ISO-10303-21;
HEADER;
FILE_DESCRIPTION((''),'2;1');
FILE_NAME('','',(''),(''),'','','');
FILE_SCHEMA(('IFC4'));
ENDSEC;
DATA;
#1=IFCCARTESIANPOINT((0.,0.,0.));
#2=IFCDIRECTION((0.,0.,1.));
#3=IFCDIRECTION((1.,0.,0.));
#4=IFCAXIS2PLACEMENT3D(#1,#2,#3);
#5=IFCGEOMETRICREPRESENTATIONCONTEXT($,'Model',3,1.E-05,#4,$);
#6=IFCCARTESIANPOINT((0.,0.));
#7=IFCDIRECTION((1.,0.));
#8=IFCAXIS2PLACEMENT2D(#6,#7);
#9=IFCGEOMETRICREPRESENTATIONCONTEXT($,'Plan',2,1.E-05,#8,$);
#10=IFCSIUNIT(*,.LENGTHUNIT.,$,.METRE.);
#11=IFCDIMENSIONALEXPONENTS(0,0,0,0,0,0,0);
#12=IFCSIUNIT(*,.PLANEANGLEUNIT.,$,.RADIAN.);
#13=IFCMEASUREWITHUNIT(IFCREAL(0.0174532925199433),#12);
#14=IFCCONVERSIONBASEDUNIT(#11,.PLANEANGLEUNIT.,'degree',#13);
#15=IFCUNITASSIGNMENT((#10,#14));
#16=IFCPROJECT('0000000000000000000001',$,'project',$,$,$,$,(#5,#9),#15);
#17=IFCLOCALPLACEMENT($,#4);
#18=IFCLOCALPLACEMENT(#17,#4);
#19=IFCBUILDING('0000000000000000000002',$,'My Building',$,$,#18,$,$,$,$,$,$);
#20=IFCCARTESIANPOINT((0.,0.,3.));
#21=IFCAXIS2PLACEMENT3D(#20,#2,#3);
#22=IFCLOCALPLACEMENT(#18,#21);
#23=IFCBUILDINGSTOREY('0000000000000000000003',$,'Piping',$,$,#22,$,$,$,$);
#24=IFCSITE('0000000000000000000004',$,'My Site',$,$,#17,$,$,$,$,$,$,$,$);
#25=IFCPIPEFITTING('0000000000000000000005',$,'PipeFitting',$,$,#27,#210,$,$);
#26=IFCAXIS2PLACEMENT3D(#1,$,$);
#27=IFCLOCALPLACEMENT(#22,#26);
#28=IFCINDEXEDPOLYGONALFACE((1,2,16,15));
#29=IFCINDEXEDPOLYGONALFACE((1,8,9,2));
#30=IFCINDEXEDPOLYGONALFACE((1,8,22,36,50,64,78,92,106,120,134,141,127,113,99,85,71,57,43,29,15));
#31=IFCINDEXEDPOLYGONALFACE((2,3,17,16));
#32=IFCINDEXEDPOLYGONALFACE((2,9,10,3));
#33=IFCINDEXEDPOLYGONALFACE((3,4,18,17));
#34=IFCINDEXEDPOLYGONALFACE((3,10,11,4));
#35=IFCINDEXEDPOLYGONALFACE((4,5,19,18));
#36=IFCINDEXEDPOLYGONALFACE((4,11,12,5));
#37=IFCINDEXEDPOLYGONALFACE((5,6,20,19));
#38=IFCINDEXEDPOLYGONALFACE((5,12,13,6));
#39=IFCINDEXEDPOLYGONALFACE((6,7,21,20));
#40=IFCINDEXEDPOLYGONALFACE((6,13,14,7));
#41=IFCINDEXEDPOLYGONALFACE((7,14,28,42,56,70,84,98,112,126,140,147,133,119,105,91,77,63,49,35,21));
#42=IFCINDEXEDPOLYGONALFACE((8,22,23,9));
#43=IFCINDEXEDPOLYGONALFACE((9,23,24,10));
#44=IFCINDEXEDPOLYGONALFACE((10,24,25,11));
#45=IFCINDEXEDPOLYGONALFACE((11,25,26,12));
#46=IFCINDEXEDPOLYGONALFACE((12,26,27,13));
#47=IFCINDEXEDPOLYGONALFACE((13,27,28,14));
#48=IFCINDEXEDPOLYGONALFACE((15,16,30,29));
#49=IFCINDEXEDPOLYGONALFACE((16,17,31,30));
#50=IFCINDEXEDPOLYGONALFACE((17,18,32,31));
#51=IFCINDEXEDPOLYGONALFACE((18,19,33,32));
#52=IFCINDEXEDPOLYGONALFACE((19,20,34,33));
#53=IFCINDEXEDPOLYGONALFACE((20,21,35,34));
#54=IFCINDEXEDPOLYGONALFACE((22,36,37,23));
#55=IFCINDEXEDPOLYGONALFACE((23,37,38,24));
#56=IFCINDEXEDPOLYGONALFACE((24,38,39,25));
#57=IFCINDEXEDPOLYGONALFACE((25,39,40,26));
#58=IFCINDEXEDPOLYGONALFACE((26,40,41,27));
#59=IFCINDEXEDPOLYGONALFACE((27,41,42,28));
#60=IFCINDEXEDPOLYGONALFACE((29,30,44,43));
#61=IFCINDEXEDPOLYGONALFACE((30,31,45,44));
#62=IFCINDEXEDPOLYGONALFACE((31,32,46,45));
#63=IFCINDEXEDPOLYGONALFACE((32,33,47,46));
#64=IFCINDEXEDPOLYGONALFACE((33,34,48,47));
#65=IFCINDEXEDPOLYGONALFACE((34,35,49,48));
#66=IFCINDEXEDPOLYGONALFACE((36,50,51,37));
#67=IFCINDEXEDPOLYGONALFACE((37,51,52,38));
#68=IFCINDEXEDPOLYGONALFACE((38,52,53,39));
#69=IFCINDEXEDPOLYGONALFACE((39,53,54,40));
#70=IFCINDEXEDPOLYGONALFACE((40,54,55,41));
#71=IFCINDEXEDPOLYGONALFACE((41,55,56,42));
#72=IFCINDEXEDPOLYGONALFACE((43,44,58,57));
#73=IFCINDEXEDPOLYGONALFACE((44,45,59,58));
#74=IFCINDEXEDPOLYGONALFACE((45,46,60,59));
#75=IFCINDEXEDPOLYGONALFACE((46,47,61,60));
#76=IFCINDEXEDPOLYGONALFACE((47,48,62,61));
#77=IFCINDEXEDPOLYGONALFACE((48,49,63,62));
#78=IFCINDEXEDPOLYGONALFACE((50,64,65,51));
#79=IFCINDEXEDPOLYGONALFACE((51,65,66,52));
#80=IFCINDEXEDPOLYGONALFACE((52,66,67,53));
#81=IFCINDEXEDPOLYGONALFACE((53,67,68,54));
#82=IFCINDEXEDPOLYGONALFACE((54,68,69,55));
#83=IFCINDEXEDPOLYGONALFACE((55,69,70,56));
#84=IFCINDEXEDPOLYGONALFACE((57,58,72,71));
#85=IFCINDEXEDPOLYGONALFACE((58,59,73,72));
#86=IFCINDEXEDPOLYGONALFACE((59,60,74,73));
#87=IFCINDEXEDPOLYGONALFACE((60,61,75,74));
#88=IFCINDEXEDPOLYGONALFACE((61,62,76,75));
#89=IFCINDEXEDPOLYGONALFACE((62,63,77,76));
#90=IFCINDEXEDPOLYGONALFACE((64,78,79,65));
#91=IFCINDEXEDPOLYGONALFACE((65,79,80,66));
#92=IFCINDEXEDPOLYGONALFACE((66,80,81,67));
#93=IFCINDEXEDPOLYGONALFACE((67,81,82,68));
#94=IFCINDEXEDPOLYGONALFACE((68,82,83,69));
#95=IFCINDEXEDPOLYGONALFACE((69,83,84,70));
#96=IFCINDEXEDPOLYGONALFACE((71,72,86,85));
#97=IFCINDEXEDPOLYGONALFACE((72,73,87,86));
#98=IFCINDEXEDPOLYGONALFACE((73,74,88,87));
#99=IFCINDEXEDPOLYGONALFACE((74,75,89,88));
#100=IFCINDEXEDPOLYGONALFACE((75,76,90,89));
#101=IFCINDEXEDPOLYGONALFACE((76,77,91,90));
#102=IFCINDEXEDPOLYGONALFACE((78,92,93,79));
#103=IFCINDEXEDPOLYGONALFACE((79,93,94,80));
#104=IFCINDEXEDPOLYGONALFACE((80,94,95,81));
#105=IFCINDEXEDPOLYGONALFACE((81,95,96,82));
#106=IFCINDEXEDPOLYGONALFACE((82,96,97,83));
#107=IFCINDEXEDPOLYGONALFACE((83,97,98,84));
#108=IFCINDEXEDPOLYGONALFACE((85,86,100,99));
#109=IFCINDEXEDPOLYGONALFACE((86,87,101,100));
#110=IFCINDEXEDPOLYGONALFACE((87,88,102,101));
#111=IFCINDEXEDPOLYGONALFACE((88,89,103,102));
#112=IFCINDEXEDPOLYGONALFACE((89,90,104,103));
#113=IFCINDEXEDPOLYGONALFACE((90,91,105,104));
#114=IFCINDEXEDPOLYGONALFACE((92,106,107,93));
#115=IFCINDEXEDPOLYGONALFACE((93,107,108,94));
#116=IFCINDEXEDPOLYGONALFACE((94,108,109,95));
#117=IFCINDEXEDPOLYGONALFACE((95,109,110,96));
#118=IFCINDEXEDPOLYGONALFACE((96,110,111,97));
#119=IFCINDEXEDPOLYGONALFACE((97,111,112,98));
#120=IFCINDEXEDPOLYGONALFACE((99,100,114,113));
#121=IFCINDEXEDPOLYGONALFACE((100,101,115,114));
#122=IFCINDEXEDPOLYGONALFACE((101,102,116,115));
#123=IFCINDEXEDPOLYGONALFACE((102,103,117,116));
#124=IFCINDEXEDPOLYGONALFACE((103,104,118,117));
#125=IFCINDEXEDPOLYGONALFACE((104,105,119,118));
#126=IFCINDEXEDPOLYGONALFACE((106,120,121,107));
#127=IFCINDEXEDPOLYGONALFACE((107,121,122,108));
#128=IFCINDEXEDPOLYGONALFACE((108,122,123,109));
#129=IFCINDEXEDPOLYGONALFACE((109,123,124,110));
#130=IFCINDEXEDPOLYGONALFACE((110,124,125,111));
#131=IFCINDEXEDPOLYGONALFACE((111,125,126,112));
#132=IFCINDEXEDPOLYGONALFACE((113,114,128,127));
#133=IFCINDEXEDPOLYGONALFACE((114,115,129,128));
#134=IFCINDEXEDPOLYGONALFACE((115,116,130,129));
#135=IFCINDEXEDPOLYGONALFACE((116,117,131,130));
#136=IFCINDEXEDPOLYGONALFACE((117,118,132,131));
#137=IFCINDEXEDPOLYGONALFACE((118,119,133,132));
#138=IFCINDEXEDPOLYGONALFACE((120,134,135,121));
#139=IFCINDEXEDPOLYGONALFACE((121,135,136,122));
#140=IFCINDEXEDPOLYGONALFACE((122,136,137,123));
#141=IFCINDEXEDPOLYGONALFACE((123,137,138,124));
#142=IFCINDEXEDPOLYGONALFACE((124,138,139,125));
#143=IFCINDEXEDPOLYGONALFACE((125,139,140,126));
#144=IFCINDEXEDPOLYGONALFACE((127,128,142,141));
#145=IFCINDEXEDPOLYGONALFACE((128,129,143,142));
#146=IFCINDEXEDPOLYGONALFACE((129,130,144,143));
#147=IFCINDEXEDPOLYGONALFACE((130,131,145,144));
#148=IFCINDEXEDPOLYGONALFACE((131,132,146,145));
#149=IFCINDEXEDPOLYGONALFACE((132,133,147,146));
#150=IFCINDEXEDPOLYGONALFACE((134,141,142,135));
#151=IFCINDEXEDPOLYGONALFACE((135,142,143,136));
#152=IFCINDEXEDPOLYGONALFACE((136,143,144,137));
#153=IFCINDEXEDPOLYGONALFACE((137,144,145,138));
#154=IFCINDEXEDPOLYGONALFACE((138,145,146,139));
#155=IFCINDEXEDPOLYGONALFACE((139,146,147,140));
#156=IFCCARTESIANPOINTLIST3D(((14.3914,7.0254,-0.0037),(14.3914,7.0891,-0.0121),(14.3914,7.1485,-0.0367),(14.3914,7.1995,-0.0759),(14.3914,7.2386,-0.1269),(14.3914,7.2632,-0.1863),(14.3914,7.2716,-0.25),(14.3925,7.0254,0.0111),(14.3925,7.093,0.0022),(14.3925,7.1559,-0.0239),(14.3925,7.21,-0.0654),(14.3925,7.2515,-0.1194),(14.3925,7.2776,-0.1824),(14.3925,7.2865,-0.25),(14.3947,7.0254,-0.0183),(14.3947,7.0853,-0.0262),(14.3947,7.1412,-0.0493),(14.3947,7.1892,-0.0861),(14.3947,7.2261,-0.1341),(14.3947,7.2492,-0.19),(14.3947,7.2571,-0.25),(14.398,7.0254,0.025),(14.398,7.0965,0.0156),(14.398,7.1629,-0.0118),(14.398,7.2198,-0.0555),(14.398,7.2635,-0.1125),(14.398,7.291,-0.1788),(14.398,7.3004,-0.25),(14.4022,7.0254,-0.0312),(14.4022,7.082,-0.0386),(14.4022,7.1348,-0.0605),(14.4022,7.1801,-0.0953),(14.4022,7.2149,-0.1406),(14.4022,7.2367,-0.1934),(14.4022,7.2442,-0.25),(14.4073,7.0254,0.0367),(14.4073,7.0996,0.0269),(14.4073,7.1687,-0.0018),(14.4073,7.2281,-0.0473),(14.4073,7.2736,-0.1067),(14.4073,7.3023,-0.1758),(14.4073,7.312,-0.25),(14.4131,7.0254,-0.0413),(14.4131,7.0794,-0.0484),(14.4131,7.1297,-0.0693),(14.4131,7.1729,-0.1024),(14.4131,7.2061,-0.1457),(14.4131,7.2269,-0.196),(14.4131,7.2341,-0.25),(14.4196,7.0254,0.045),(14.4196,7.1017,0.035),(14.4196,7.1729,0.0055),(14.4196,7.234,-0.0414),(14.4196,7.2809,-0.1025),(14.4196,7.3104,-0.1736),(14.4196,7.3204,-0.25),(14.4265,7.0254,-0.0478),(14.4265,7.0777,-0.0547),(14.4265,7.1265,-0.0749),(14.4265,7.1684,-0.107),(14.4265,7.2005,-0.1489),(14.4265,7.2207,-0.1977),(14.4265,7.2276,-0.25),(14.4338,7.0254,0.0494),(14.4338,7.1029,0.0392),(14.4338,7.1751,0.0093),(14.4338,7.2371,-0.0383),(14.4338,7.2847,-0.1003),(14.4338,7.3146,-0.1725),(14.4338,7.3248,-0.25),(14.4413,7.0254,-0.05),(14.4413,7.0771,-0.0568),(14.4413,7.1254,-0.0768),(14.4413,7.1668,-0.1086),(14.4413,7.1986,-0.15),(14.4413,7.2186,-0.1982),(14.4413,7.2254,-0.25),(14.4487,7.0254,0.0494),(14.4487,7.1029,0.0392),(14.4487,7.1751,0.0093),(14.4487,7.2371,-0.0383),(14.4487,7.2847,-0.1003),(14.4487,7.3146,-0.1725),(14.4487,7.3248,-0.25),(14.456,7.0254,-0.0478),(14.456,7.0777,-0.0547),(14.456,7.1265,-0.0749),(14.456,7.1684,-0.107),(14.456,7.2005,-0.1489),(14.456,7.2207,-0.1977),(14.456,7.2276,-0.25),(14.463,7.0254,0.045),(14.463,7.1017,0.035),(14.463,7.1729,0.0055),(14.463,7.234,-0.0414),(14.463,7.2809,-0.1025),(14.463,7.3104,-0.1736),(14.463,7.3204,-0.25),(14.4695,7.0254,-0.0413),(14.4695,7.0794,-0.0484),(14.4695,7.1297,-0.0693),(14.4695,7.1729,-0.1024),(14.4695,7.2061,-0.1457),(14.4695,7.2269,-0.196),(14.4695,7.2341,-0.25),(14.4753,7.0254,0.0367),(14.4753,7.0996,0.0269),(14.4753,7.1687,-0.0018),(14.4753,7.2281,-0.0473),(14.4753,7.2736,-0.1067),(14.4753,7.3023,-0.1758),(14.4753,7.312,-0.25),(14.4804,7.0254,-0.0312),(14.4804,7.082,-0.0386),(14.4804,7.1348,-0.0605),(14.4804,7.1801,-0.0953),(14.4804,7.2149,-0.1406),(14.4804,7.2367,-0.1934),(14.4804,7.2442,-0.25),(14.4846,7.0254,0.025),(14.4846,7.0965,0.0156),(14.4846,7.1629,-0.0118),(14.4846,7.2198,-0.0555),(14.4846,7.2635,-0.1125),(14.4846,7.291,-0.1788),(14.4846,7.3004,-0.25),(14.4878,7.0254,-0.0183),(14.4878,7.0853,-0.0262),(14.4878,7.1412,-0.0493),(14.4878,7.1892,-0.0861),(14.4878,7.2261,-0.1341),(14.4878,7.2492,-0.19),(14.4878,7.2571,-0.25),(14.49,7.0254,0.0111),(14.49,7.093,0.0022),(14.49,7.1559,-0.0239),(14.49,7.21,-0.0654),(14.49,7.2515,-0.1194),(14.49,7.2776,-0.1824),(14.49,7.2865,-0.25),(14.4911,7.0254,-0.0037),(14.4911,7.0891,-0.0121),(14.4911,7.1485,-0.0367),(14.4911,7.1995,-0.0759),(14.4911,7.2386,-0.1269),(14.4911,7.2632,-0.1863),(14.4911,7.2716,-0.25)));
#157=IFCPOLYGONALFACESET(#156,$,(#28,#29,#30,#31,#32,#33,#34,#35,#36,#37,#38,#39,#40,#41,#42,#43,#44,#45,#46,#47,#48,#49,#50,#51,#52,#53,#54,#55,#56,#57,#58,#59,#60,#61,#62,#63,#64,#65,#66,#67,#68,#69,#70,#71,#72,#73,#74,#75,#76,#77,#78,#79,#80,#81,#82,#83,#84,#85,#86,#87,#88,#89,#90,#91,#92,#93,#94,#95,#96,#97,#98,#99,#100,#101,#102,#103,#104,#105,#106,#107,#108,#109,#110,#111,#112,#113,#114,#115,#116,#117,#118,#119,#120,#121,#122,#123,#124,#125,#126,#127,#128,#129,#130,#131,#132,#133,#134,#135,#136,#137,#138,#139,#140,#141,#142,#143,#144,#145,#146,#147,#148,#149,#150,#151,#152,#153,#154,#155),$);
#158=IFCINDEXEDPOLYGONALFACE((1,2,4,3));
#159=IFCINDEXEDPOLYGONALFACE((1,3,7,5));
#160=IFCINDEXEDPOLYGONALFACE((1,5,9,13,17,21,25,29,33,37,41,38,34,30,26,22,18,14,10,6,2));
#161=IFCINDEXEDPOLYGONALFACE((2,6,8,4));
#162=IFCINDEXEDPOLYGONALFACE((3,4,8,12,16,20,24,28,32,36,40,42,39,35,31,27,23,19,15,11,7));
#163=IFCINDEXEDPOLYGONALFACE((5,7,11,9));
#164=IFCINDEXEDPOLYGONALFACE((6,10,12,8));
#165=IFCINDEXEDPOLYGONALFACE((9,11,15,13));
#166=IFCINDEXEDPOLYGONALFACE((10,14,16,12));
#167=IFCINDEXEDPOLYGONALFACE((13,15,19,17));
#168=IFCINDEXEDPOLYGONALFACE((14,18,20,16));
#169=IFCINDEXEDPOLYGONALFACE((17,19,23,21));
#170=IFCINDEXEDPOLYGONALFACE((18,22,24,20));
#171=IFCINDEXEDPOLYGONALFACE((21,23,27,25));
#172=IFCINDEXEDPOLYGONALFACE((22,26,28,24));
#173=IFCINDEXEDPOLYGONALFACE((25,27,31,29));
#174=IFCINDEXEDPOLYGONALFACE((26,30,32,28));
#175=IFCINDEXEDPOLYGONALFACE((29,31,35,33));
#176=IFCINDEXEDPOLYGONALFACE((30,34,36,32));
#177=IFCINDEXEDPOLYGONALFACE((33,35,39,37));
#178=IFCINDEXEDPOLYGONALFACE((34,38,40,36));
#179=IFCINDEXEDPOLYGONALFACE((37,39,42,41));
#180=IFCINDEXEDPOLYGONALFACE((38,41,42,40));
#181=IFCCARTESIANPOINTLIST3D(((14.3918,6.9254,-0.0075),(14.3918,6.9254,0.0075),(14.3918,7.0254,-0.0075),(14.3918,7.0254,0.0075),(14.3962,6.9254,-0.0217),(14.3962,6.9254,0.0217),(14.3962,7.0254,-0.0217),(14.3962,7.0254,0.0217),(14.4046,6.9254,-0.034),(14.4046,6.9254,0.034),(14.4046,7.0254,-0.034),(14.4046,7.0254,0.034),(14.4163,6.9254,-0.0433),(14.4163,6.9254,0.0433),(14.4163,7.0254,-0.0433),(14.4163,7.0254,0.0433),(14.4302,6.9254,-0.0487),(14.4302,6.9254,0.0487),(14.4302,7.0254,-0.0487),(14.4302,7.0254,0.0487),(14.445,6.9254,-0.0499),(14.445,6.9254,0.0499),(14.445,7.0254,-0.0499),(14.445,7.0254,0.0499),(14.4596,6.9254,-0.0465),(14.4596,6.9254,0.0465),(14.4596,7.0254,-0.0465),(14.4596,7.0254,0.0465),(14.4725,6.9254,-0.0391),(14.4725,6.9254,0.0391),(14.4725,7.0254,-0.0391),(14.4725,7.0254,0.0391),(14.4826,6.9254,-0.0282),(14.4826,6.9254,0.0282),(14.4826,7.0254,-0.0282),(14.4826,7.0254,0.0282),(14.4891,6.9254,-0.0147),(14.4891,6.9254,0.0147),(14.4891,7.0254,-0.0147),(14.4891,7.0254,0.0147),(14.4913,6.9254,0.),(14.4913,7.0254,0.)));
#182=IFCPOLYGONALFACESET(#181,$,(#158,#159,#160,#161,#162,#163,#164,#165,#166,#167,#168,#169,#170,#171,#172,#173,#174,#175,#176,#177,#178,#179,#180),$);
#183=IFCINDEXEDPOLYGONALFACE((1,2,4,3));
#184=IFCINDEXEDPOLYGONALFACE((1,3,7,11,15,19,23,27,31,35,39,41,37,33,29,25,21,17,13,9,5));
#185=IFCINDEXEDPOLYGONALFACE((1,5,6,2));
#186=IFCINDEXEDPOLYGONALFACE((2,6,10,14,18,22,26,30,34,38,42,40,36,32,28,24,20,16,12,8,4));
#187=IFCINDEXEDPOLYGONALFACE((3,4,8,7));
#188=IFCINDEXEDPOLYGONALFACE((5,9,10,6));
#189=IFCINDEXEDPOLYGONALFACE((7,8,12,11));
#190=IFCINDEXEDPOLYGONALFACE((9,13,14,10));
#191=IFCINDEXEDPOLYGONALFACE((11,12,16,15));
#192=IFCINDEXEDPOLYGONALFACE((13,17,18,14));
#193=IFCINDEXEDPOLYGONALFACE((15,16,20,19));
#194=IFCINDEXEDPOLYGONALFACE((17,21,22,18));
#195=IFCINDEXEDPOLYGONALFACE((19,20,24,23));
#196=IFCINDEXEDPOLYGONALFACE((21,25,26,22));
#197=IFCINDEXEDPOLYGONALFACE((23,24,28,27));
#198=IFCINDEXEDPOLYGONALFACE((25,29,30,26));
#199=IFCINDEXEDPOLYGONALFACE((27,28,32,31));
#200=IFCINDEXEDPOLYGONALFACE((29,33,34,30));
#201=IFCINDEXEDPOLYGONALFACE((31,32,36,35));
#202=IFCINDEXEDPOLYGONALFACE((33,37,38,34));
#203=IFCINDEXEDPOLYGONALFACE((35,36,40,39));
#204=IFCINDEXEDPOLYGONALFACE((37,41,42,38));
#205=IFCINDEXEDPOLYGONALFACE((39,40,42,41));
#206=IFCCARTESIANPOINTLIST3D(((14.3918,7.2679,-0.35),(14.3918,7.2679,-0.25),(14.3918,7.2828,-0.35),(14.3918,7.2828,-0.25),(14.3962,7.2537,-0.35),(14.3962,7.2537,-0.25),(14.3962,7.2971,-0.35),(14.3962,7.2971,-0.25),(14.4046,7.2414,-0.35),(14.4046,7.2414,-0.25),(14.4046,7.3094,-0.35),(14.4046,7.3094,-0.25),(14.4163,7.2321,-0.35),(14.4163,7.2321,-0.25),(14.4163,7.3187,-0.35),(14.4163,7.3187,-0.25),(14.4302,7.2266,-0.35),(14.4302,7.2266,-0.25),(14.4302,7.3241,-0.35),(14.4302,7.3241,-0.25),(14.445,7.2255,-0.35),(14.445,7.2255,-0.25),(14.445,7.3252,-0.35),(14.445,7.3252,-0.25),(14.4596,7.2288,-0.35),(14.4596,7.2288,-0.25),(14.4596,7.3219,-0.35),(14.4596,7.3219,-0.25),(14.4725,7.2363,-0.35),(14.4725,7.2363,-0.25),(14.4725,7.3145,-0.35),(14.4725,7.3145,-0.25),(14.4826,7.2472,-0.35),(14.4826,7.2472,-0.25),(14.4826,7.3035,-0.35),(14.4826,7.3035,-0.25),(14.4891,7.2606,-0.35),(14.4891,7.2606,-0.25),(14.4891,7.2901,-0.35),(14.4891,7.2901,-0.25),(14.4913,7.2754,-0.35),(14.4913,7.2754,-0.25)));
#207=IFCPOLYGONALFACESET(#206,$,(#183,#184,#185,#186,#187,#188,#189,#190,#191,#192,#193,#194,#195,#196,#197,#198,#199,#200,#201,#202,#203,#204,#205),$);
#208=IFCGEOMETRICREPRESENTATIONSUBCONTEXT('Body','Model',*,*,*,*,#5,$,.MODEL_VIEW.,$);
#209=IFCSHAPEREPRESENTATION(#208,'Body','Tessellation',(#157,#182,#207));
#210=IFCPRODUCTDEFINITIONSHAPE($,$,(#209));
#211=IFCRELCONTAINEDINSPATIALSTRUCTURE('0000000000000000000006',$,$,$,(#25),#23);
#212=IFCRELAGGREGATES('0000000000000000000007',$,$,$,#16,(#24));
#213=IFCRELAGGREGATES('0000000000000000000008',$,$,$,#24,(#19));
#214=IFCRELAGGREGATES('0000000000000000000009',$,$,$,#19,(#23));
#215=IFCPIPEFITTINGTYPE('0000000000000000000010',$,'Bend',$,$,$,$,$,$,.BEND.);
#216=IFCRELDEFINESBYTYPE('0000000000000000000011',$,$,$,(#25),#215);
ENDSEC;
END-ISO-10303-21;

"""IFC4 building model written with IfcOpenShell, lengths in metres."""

from ifc_helpers import new_model, entity, si_unit, converted_unit, frame, origin_with_axes, origin_2d_with_axis, place, context, subcontext, project, spatial, circle, extrude, source, transform, mapped, type_object, type_shapes, element, save


model = new_model("IFC4")

# Units and contexts
model_context = context("Model", 3, precision=1e-05, world=origin_with_axes())
plan_context = context("Plan", 2, precision=1e-05, world=origin_2d_with_axis())
body_context = subcontext(model_context, "Body", "Model", "MODEL_VIEW")
ifc_project = project(units=[si_unit("LENGTHUNIT", "METRE"), converted_unit("PLANEANGLEUNIT", "degree", entity("IfcReal", 0.0174532925199433), si_unit("PLANEANGLEUNIT", "RADIAN"), dimensions=[0, 0, 0, 0, 0, 0, 0])], contexts=[model_context, plan_context])

# Site, building, storey
site_placement = place(None, origin_with_axes())
site = spatial("IfcSite", under=ifc_project, at=site_placement, Name="My Site")
building_placement = place(site_placement, origin_with_axes())
building = spatial("IfcBuilding", under=site, at=building_placement, Name="My Building")
storey_placement = place(building_placement, frame((0.0, 0.0, 3.0), z_axis=(0.0, 0.0, 1.0), x_axis=(1.0, 0.0, 0.0)))
storey = spatial("IfcBuildingStorey", under=building, at=storey_placement, Name="Piping")

# Pipe fitting
pipe_fitting_type = type_object("IfcPipeFittingType", Name="Bend", PredefinedType="BEND")
shared_shape = source(origin_with_axes(), body_context, "Body", "SolidModel", [
    entity("IfcSweptDiskSolid", entity("IfcIndexedPolyCurve", entity("IfcCartesianPointList3D", [[0.0, 0.0, -0.1], [0.0, -0.0732, -0.2768], [0.0, -0.25, -0.35]]), [entity("IfcArcIndex", [1, 2, 3])]), 0.05),
    extrude(circle(Radius=0.05), origin_with_axes(), (0.0, 0.0, -1.0), 0.1),
    extrude(circle(Radius=0.05), frame((0.0, -0.25, -0.35), z_axis=(0.0, -1.0, 0.0), x_axis=(1.0, 0.0, 0.0)), (0.0, 0.0, 1.0), 0.1),
])
type_shapes(pipe_fitting_type, [shared_shape])
for number, where, z_axis, x_axis, name in (
    (1, (14.4413, 6.9254, 0.0), (0.0, -1.0, 0.0), (1.0, 0.0, 0.0), "PipeFitting"),
):
    element("IfcPipeFitting", number, at=place(storey_placement, frame(where, z_axis=z_axis, x_axis=x_axis)), inside=storey, type_object=pipe_fitting_type, Name=name, context=body_context, shape_type="MappedRepresentation", body=[
        mapped(shared_shape, transform((0.0, 0.0, 0.0), x_axis=(1.0, 0.0, 0.0), y_axis=(0.0, 1.0, 0.0), z_axis=(0.0, 0.0, 1.0), scale=1.0)),
    ])

save(model, "model.ifc")
